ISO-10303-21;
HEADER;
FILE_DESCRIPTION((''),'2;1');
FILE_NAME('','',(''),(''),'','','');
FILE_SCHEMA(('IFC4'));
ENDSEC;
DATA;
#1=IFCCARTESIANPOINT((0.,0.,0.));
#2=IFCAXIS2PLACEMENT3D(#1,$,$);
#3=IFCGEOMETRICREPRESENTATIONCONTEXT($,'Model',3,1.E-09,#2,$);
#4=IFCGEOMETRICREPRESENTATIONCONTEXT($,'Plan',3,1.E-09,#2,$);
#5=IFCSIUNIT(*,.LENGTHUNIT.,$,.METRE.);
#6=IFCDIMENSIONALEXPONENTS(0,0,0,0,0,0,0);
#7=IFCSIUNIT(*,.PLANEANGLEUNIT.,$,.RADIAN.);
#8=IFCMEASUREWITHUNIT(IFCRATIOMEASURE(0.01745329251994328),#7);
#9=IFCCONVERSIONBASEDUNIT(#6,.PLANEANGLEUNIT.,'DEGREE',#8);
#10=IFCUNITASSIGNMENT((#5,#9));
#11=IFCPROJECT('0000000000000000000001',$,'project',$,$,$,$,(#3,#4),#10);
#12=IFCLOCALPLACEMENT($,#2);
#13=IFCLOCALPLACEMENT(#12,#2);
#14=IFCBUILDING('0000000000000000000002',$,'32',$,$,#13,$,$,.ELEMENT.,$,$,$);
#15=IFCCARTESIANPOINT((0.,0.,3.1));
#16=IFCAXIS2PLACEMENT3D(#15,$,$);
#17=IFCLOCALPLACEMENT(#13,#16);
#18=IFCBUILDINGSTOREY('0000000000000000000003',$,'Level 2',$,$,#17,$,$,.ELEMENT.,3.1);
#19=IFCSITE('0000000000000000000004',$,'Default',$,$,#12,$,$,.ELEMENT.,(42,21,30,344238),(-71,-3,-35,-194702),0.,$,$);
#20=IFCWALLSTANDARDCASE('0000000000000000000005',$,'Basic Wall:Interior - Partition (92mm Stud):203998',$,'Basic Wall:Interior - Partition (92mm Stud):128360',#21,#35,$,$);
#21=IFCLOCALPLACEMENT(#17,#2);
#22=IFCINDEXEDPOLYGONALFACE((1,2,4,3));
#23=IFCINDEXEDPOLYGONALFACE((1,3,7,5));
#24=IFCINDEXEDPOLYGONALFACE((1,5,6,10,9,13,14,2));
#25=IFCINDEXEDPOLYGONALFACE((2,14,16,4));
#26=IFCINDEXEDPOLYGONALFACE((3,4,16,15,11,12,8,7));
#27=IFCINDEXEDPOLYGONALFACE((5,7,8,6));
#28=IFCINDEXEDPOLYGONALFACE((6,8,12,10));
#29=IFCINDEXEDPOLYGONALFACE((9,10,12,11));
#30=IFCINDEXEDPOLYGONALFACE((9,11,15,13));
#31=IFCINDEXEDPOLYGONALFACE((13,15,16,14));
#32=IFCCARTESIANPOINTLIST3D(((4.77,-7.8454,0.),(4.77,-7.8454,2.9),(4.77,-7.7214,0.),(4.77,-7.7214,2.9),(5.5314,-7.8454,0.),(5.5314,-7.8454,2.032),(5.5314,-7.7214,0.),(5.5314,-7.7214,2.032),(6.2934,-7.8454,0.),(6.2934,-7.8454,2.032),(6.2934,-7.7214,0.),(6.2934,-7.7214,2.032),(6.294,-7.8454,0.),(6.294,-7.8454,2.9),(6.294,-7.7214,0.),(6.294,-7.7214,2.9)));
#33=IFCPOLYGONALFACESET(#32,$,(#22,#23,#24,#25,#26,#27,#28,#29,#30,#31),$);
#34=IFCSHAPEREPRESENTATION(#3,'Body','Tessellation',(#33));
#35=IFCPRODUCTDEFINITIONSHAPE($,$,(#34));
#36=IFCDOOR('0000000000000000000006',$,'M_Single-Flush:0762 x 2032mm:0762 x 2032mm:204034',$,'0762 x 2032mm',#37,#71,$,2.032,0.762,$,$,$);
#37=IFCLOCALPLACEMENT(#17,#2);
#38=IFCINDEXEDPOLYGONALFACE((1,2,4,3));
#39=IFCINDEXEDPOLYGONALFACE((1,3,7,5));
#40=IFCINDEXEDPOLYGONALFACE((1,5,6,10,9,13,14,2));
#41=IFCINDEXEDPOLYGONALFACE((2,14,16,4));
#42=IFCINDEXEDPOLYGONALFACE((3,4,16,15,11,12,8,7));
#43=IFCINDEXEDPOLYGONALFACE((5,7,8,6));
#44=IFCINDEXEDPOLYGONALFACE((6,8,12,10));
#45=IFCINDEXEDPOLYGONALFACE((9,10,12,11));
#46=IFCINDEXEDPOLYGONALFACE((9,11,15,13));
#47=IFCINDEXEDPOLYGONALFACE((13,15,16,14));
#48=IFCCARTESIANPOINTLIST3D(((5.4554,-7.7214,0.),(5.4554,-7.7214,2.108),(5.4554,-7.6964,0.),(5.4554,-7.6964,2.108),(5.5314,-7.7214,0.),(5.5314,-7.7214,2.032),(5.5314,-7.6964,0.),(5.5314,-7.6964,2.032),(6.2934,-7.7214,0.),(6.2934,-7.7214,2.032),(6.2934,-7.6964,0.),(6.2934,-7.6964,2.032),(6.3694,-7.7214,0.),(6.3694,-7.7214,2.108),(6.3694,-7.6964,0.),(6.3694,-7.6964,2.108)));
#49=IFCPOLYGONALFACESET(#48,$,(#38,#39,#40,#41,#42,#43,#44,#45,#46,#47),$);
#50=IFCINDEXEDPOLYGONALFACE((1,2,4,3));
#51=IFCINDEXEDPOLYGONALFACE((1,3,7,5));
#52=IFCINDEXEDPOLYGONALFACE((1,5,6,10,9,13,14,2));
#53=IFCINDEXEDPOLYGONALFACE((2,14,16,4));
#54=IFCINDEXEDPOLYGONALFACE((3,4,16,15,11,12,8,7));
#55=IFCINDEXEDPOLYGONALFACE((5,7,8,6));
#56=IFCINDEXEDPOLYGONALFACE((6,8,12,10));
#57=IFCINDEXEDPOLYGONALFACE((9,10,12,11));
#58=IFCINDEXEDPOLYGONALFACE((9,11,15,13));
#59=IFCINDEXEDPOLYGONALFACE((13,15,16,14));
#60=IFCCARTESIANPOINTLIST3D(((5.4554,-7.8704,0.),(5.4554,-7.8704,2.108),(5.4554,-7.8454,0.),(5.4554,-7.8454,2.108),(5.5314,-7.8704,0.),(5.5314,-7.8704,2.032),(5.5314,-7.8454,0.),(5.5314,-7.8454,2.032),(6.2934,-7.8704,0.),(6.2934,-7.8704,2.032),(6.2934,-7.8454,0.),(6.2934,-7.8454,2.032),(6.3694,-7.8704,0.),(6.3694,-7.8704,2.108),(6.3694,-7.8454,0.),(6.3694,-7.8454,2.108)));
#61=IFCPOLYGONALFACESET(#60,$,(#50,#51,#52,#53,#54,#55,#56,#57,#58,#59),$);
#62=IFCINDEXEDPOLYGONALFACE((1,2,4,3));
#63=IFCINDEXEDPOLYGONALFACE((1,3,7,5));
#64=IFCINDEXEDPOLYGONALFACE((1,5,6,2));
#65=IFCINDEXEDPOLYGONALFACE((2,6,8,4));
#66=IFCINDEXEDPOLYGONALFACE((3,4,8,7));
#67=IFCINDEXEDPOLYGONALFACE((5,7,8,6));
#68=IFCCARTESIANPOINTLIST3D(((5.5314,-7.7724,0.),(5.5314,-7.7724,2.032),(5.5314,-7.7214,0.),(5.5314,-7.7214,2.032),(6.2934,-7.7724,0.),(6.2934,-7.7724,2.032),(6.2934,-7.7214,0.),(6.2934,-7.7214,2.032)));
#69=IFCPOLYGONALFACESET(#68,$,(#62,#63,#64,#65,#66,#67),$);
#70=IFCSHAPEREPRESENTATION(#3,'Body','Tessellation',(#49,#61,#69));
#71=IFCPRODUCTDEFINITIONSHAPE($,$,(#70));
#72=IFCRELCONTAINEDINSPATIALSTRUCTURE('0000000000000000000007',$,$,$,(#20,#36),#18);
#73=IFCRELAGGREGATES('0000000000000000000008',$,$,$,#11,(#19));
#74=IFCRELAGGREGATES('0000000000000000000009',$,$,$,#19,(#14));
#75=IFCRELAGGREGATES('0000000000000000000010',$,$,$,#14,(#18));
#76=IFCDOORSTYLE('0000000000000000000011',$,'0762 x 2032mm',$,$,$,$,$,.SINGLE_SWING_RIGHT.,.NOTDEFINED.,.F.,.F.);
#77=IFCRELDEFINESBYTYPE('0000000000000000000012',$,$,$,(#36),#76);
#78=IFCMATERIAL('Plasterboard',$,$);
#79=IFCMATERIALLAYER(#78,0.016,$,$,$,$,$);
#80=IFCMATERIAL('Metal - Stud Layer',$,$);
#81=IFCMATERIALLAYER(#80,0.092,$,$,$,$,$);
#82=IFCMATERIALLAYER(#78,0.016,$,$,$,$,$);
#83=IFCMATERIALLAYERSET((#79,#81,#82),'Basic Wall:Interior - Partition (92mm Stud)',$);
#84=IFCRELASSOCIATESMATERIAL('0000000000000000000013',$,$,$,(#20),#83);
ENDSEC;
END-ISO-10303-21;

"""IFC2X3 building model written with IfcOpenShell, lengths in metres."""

from ifc_helpers import new_model, entity, si_unit, converted_unit, frame, frame_2d, origin, origin_2d_with_axis, place, context, project, spatial, polyline, rectangle, outline, extrude, source, transform, mapped, material, layer, layer_set, layer_usage, type_object, type_shapes, element, fill, save


model = new_model("IFC2X3")

# Units and contexts
model_context = context("Model", 3, precision=1e-09, world=origin())
plan_context = context("Plan", 3, precision=1e-09, world=origin())
ifc_project = project(units=[si_unit("LENGTHUNIT", "METRE"), converted_unit("PLANEANGLEUNIT", "DEGREE", entity("IfcRatioMeasure", 0.01745329251994328), si_unit("PLANEANGLEUNIT", "RADIAN"), dimensions=[0, 0, 0, 0, 0, 0, 0])], contexts=[model_context, plan_context])

# Site, building, storey
site_placement = place(None, origin())
site = spatial("IfcSite", under=ifc_project, at=site_placement, Name="Default", CompositionType="ELEMENT", RefLatitude=(42, 21, 30, 344238), RefLongitude=(-71, -3, -35, -194702), RefElevation=0.0)
building_placement = place(site_placement, origin())
building = spatial("IfcBuilding", under=site, at=building_placement, Name="32", CompositionType="ELEMENT")
storey_placement = place(building_placement, frame((0.0, 0.0, 3.1)))
storey = spatial("IfcBuildingStorey", under=building, at=storey_placement, Name="Level 2", CompositionType="ELEMENT", Elevation=3.1)

# Shared definitions
ifc_material_1 = material(Name="Plasterboard")
ifc_material_2 = material(Name="Metal - Stud Layer")
ifc_layer_1 = layer(ifc_material_1, 0.016)
ifc_layer_2 = layer(ifc_material_2, 0.092)
ifc_layer_3 = layer(ifc_material_1, 0.016)
ifc_layer_set_1 = layer_set([ifc_layer_1, ifc_layer_2, ifc_layer_3], Name="Basic Wall:Interior - Partition (92mm Stud)")

# Wall, opening, door
door_style = type_object("IfcDoorStyle", Name="0762 x 2032mm", ConstructionType="NOTDEFINED", OperationType="SINGLE_SWING_RIGHT", ParameterTakesPrecedence=False, Sizeable=False)
shared_shape = source(origin(), model_context, "Body", "SweptSolid", [
    extrude(outline(polyline([(-0.457, -1.073), (0.457, -1.073), (0.457, 1.035), (0.381, 1.035), (0.381, -0.997), (-0.381, -0.997), (-0.381, 1.035), (-0.457, 1.035), (-0.457, -1.073)])), frame((0.381, 0.124, 1.035), z_axis=(0.0, 1.0, 0.0), x_axis=(1.0, 0.0, 0.0)), (0.0, 0.0, 1.0), 0.025),
    extrude(outline(polyline([(-1.073, -0.457), (1.035, -0.457), (1.035, -0.381), (-0.997, -0.381), (-0.997, 0.381), (1.035, 0.381), (1.035, 0.457), (-1.073, 0.457), (-1.073, -0.457)])), frame((0.381, -0.025, 1.035), z_axis=(0.0, 1.0, 0.0), x_axis=(0.0, 0.0, -1.0)), (0.0, 0.0, 1.0), 0.025),
    extrude(rectangle(XDim=0.051, YDim=0.762, at=origin_2d_with_axis()), frame((0.381, 0.0985, 0.0), z_axis=(0.0, 0.0, 1.0), x_axis=(0.0, 1.0, 0.0)), (0.0, 0.0, 1.0), 2.032),
])
type_shapes(door_style, [shared_shape])
ifc_layer_usage_1 = layer_usage(ifc_layer_set_1, "AXIS2", "POSITIVE", -0.062)
wall_1_placement = place(storey_placement, frame((4.77, -7.7834, 0.0)))
wall_1 = element("IfcWallStandardCase", 1, at=wall_1_placement, inside=storey, material=ifc_layer_usage_1, Name="Basic Wall:Interior - Partition (92mm Stud):203998", ObjectType="Basic Wall:Interior - Partition (92mm Stud):128360", context=model_context, shape_type="SweptSolid", body=[
    extrude(rectangle(XDim=1.524, YDim=0.124, at=frame_2d((0.762, 0.0), x_axis=(-1.0, 0.0))), origin(), (0.0, 0.0, 1.0), 2.9),
])
opening_1_placement = place(wall_1_placement, frame((0.7614, -0.062, 0.0)))
opening_1 = element("IfcOpeningElement", 2, at=opening_1_placement, cuts=wall_1, ObjectType="Opening", context=model_context, shape_type="SweptSolid", body=[
    extrude(rectangle(XDim=0.762, YDim=2.032, at=frame_2d((1.016, 0.381), x_axis=(0.0, 1.0))), frame((0.0, 0.0, 0.0), z_axis=(0.0, 1.0, 0.0), x_axis=(0.0, 0.0, 1.0)), (0.0, 0.0, 1.0), 0.124),
])
door_1_placement = place(opening_1_placement, origin())
door_1 = element("IfcDoor", 3, at=door_1_placement, inside=storey, type_object=door_style, Name="M_Single-Flush:0762 x 2032mm:0762 x 2032mm:204034", ObjectType="0762 x 2032mm", OverallHeight=2.032, OverallWidth=0.762, context=model_context, shape_type="MappedRepresentation", body=[
    mapped(shared_shape, transform((0.0, 0.0, 0.0), scale=1.0)),
])
fill(opening_1, door_1)

save(model, "model.ifc")
